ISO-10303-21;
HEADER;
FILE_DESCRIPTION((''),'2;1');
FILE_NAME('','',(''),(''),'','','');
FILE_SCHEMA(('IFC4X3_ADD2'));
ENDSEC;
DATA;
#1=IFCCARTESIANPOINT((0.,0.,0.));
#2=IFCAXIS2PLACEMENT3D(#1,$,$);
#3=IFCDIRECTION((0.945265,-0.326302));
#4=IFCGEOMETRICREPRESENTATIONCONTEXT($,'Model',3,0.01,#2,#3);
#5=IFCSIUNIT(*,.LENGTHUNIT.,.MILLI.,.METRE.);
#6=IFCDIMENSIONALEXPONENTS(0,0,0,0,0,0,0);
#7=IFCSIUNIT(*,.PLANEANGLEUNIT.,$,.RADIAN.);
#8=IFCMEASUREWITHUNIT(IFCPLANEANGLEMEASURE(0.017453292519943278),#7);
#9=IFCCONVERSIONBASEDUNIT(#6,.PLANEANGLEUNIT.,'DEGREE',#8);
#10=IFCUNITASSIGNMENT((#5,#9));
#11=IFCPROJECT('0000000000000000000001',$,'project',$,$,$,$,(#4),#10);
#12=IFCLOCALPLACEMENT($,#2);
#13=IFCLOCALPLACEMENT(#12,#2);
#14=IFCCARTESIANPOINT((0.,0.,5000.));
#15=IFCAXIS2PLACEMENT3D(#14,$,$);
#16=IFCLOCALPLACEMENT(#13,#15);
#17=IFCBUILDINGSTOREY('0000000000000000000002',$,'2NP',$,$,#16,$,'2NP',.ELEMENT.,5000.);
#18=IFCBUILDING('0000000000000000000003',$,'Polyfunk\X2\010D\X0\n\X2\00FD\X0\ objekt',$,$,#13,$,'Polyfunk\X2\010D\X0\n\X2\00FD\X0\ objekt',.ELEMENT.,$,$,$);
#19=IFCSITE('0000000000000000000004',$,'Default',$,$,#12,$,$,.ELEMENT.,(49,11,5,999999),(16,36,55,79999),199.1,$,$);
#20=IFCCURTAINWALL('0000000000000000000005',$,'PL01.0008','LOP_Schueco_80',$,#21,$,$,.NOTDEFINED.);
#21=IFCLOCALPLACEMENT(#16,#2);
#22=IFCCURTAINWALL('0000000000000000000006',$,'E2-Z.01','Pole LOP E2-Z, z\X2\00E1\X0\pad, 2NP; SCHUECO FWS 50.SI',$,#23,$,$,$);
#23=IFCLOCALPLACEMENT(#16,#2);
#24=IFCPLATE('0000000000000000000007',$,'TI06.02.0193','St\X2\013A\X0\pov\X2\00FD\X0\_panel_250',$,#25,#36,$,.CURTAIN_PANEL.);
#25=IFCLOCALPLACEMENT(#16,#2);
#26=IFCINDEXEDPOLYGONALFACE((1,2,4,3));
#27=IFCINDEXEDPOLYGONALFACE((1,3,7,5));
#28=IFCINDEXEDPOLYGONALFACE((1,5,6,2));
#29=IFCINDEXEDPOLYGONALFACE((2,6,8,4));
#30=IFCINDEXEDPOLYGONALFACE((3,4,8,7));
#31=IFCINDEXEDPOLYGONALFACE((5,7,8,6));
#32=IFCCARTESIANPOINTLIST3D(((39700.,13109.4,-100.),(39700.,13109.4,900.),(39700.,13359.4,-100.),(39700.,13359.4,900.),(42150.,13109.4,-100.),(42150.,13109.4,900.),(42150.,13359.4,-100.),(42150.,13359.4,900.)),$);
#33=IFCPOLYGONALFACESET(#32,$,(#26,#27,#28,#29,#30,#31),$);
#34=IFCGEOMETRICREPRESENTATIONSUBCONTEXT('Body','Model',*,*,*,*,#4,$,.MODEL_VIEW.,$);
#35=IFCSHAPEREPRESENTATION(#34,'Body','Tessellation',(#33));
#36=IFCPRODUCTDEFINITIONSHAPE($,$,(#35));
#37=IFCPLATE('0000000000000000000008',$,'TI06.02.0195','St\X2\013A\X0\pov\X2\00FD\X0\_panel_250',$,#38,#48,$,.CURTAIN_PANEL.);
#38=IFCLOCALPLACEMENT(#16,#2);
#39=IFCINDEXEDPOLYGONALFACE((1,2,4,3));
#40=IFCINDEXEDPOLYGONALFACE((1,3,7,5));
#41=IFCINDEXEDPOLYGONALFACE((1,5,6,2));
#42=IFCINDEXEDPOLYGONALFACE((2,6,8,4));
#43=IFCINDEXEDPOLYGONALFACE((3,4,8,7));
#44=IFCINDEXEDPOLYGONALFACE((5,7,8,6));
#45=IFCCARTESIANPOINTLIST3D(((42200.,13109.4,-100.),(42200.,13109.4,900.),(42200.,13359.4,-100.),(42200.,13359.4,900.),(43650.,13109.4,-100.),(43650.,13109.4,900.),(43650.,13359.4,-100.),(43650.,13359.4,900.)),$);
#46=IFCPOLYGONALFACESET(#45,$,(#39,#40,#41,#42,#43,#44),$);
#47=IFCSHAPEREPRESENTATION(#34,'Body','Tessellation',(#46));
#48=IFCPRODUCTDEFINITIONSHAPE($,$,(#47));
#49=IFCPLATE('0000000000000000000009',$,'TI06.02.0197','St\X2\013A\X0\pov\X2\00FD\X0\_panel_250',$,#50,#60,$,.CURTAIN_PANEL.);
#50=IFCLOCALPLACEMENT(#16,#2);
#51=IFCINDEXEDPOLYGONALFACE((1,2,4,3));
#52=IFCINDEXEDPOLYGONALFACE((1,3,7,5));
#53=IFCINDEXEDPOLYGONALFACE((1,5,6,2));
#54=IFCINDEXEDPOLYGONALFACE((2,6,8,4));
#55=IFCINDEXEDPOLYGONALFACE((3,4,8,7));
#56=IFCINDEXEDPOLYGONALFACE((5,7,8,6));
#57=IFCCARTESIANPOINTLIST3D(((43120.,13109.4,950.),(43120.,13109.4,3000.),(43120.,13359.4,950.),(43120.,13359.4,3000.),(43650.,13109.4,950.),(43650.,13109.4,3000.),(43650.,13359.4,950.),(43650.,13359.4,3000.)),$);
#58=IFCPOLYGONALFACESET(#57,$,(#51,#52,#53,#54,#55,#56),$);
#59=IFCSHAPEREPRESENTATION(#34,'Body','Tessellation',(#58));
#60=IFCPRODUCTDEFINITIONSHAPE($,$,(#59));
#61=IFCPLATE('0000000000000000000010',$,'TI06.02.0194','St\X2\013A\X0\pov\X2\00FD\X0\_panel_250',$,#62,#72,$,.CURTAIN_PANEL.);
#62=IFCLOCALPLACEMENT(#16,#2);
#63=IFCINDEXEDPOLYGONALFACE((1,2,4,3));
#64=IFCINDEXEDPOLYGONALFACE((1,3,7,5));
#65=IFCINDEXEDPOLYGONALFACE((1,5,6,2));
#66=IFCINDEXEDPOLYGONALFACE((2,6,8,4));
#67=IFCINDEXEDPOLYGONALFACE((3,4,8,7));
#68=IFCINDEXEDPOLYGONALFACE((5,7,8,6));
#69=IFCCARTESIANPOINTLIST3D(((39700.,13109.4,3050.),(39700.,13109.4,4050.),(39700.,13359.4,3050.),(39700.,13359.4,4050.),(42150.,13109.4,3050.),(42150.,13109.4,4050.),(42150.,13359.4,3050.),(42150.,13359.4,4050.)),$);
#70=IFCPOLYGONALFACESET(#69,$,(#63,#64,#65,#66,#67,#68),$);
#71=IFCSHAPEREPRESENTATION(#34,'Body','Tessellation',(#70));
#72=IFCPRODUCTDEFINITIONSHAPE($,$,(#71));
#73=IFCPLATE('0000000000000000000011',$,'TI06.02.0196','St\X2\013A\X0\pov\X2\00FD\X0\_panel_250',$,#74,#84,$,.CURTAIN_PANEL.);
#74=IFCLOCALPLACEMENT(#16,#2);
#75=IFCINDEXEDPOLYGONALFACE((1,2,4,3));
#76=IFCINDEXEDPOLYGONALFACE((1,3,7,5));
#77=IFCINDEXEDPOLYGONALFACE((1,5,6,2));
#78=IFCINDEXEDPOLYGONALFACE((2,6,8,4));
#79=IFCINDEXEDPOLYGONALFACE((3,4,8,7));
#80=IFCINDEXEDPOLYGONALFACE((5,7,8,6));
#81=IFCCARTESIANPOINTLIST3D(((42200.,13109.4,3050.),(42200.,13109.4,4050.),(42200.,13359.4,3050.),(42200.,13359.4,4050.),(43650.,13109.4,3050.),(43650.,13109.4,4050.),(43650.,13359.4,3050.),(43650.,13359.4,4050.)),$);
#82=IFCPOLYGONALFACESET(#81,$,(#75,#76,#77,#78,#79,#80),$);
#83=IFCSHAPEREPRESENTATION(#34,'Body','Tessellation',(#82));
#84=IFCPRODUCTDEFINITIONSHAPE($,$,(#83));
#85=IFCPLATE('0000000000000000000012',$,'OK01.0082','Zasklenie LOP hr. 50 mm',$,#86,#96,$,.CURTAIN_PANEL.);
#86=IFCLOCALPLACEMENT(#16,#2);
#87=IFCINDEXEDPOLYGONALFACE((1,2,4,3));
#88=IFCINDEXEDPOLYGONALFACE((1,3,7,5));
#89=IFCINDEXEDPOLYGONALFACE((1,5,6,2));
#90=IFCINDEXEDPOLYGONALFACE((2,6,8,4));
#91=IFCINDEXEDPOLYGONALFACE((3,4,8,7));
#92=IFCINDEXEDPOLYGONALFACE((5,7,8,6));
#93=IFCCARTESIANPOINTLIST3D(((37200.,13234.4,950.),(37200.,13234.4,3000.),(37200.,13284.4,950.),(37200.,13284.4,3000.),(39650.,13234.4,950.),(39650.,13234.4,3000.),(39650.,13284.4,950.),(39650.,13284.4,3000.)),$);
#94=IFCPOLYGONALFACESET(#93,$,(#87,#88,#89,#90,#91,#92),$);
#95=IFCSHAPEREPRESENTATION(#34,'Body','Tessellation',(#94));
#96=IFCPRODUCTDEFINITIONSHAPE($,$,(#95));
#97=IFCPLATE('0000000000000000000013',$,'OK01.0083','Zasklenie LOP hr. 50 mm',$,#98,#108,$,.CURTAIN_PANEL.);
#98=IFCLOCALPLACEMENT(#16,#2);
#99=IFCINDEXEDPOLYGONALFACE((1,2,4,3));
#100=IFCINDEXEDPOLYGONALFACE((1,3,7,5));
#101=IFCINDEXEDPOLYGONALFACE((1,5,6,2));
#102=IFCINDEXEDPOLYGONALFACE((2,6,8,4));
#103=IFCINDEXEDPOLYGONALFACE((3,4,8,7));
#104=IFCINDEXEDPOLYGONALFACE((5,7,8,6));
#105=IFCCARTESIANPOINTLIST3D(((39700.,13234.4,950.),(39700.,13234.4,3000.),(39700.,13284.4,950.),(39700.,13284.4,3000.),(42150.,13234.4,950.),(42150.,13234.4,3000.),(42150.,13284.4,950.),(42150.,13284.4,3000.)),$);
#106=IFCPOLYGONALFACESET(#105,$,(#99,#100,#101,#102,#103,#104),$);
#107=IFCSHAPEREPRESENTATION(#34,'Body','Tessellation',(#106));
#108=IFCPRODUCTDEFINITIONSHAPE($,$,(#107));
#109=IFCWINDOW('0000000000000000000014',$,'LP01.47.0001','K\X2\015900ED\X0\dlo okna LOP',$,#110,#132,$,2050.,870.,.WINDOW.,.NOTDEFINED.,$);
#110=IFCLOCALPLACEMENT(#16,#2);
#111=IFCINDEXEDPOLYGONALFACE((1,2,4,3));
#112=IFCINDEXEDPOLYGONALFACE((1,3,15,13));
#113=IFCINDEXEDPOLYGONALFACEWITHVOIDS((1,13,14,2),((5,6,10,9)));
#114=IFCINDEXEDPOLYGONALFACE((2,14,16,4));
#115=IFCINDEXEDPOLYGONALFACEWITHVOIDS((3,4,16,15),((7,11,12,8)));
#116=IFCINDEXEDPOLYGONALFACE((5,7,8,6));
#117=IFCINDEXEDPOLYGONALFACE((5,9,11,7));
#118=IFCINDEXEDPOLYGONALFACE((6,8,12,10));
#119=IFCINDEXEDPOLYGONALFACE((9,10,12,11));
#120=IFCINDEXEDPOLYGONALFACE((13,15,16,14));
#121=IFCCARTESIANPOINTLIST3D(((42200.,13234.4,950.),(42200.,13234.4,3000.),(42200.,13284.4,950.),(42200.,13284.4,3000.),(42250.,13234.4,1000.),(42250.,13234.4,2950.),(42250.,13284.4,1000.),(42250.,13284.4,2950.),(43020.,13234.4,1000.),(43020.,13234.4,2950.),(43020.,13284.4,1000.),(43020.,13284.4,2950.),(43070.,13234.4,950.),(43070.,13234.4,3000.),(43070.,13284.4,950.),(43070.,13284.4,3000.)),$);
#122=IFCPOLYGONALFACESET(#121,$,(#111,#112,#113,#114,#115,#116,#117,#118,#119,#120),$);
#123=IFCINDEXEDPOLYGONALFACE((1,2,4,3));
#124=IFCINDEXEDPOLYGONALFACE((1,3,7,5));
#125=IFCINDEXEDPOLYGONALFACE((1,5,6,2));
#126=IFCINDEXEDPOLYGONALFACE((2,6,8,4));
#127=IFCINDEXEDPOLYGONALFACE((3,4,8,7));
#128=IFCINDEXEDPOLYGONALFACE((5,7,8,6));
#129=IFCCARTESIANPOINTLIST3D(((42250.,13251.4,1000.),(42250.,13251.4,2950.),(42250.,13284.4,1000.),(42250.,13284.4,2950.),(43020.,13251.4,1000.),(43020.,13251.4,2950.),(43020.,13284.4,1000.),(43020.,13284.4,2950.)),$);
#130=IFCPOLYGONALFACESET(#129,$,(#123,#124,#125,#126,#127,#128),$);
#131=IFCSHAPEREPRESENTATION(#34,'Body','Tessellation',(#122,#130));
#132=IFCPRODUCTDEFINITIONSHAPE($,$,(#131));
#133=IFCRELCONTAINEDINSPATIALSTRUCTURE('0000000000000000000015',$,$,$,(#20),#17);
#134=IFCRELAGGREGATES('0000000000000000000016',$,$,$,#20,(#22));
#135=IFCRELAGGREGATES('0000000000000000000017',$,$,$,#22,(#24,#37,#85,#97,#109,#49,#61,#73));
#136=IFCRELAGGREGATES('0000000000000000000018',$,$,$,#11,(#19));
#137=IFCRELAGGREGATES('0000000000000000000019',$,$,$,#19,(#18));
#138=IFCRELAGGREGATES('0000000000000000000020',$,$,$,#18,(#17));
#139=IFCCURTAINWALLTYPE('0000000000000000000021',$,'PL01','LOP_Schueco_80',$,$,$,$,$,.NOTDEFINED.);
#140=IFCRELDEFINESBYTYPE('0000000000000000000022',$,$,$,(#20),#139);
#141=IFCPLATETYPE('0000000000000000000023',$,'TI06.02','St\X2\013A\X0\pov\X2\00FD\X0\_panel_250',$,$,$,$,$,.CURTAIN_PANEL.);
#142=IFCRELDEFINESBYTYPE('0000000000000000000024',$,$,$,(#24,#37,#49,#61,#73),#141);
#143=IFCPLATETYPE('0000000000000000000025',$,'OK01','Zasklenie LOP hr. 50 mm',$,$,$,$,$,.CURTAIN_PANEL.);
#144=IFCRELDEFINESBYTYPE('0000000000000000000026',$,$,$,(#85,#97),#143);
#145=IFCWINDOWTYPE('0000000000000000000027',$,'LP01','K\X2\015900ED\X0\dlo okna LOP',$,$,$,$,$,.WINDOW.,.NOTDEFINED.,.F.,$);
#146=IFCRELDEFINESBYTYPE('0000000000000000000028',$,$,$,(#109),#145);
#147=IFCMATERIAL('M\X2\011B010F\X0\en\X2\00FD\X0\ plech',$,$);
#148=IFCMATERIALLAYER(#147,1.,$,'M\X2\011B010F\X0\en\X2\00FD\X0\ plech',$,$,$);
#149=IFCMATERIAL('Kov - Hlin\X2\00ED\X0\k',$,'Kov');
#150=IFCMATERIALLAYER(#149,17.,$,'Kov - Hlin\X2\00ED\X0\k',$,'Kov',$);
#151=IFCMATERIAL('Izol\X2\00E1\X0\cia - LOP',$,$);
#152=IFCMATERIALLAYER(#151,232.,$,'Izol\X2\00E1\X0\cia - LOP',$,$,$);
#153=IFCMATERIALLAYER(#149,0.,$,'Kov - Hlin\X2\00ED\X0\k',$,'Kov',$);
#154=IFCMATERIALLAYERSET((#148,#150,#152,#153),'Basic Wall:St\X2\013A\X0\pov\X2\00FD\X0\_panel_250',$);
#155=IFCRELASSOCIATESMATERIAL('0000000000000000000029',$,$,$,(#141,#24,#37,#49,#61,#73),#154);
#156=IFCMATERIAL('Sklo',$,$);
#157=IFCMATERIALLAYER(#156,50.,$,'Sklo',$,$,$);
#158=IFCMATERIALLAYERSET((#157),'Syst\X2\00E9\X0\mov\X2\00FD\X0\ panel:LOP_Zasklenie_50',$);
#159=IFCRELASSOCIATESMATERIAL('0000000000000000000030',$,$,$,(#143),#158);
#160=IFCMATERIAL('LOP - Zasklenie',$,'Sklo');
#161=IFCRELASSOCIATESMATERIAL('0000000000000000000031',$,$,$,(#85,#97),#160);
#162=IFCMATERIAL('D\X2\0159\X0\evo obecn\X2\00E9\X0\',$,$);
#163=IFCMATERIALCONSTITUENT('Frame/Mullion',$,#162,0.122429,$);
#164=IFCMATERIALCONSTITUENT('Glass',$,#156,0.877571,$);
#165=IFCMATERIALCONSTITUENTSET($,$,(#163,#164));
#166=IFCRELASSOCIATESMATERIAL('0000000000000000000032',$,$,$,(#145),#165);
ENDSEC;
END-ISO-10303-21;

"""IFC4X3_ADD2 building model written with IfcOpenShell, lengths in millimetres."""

from ifc_helpers import new_model, entity, si_unit, converted_unit, direction, frame, frame_2d, origin, origin_2d_with_axis, place, context, subcontext, project, spatial, polyline, rectangle, outline, extrude, source, transform, mapped, material, layer, layer_set, layer_usage, constituent, constituent_set, type_object, type_shapes, element, aggregate, save


model = new_model("IFC4X3_ADD2")

# Units and contexts
model_context = context("Model", 3, precision=0.01, world=origin(), true_north=direction((0.945265, -0.326302)))
body_context = subcontext(model_context, "Body", "Model", "MODEL_VIEW")
ifc_project = project(units=[si_unit("LENGTHUNIT", "METRE", prefix="MILLI"), converted_unit("PLANEANGLEUNIT", "DEGREE", entity("IfcPlaneAngleMeasure", 0.017453292519943278), si_unit("PLANEANGLEUNIT", "RADIAN"), dimensions=[0, 0, 0, 0, 0, 0, 0])], contexts=[model_context])

# Site, building, storey
site_placement = place(None, origin())
site = spatial("IfcSite", under=ifc_project, at=site_placement, Name="Default", CompositionType="ELEMENT", RefLatitude=(49, 11, 5, 999999), RefLongitude=(16, 36, 55, 79999), RefElevation=199.1)
building_placement = place(site_placement, origin())
building = spatial("IfcBuilding", under=site, at=building_placement, Name="Polyfunkčný objekt", LongName="Polyfunkčný objekt", CompositionType="ELEMENT")
storey_placement = place(building_placement, frame((0.0, 0.0, 5000.0)))
storey = spatial("IfcBuildingStorey", under=building, at=storey_placement, Name="2NP", LongName="2NP", CompositionType="ELEMENT", Elevation=5000.0)

# Curtain walls, plates, window
curtain_wall_type = type_object("IfcCurtainWallType", Name="PL01", Description="LOP_Schueco_80", PredefinedType="NOTDEFINED")
curtain_wall_1_placement = place(storey_placement, frame((0.0, 0.0, -5000.0)))
curtain_wall_1 = element("IfcCurtainWall", 1, at=curtain_wall_1_placement, inside=storey, type_object=curtain_wall_type, Name="PL01.0008", Description="LOP_Schueco_80", PredefinedType="NOTDEFINED")
curtain_wall_2 = element("IfcCurtainWall", 2, Name="E2-Z.01", Description="Pole LOP E2-Z, západ, 2NP; SCHUECO FWS 50.SI")
aggregate(curtain_wall_1, [curtain_wall_2])
ifc_material_1 = material(Name="Měďený plech")
ifc_layer_1 = layer(ifc_material_1, 1.0, Name="Měďený plech")
ifc_material_2 = material(Name="Kov - Hliník", Category="Kov")
ifc_layer_2 = layer(ifc_material_2, 17.0, Name="Kov - Hliník", Category="Kov")
ifc_material_3 = material(Name="Izolácia - LOP")
ifc_layer_3 = layer(ifc_material_3, 232.0, Name="Izolácia - LOP")
ifc_layer_4 = layer(ifc_material_2, 0.0, Name="Kov - Hliník", Category="Kov")
ifc_layer_set_1 = layer_set([ifc_layer_1, ifc_layer_2, ifc_layer_3, ifc_layer_4], Name="Basic Wall:Stĺpový_panel_250")
ifc_layer_usage_1 = layer_usage(ifc_layer_set_1, "AXIS2", "NEGATIVE", 125.0)
plate_type_1 = type_object("IfcPlateType", Name="TI06.02", Description="Stĺpový_panel_250", PredefinedType="CURTAIN_PANEL", material=ifc_layer_set_1)
plate_1_placement = place(storey_placement, frame((39700.0, 13234.4, -100.0)))
plate_1 = element("IfcPlate", 3, at=plate_1_placement, type_object=plate_type_1, material=ifc_layer_usage_1, Name="TI06.02.0193", Description="Stĺpový_panel_250", PredefinedType="CURTAIN_PANEL", context=body_context, shape_type="SweptSolid", body=[
    extrude(rectangle(XDim=250.0, YDim=2450.0, at=frame_2d((0.0, 0.0), x_axis=(1.0, 0.0))), frame((1225.0, 0.0, 0.0), z_axis=(0.0, 0.0, 1.0), x_axis=(0.0, 1.0, 0.0)), (0.0, 0.0, 1.0), 1000.0),
])
ifc_layer_usage_2 = layer_usage(ifc_layer_set_1, "AXIS2", "NEGATIVE", 125.0)
plate_2_placement = place(storey_placement, frame((42200.0, 13234.4, -100.0)))
plate_2 = element("IfcPlate", 4, at=plate_2_placement, type_object=plate_type_1, material=ifc_layer_usage_2, Name="TI06.02.0195", Description="Stĺpový_panel_250", PredefinedType="CURTAIN_PANEL", context=body_context, shape_type="SweptSolid", body=[
    extrude(rectangle(XDim=250.0, YDim=1450.0, at=frame_2d((0.0, 0.0), x_axis=(1.0, 0.0))), frame((725.0, 0.0, 0.0), z_axis=(0.0, 0.0, 1.0), x_axis=(0.0, 1.0, 0.0)), (0.0, 0.0, 1.0), 1000.0),
])
ifc_layer_usage_3 = layer_usage(ifc_layer_set_1, "AXIS2", "NEGATIVE", 125.0)
plate_3_placement = place(storey_placement, frame((43120.0, 13234.4, 950.0)))
plate_3 = element("IfcPlate", 5, at=plate_3_placement, type_object=plate_type_1, material=ifc_layer_usage_3, Name="TI06.02.0197", Description="Stĺpový_panel_250", PredefinedType="CURTAIN_PANEL", context=body_context, shape_type="SweptSolid", body=[
    extrude(rectangle(XDim=250.0, YDim=530.0, at=frame_2d((0.0, 0.0), x_axis=(1.0, 0.0))), frame((265.0, 0.0, 0.0), z_axis=(0.0, 0.0, 1.0), x_axis=(0.0, 1.0, 0.0)), (0.0, 0.0, 1.0), 2050.0),
])
ifc_layer_usage_4 = layer_usage(ifc_layer_set_1, "AXIS2", "NEGATIVE", 125.0)
plate_4_placement = place(storey_placement, frame((39700.0, 13234.4, 3050.0)))
plate_4 = element("IfcPlate", 6, at=plate_4_placement, type_object=plate_type_1, material=ifc_layer_usage_4, Name="TI06.02.0194", Description="Stĺpový_panel_250", PredefinedType="CURTAIN_PANEL", context=body_context, shape_type="SweptSolid", body=[
    extrude(rectangle(XDim=250.0, YDim=2450.0, at=frame_2d((0.0, 0.0), x_axis=(1.0, 0.0))), frame((1225.0, 0.0, 0.0), z_axis=(0.0, 0.0, 1.0), x_axis=(0.0, 1.0, 0.0)), (0.0, 0.0, 1.0), 1000.0),
])
ifc_layer_usage_5 = layer_usage(ifc_layer_set_1, "AXIS2", "NEGATIVE", 125.0)
plate_5_placement = place(storey_placement, frame((42200.0, 13234.4, 3050.0)))
plate_5 = element("IfcPlate", 7, at=plate_5_placement, type_object=plate_type_1, material=ifc_layer_usage_5, Name="TI06.02.0196", Description="Stĺpový_panel_250", PredefinedType="CURTAIN_PANEL", context=body_context, shape_type="SweptSolid", body=[
    extrude(rectangle(XDim=250.0, YDim=1450.0, at=frame_2d((0.0, 0.0), x_axis=(1.0, 0.0))), frame((725.0, 0.0, 0.0), z_axis=(0.0, 0.0, 1.0), x_axis=(0.0, 1.0, 0.0)), (0.0, 0.0, 1.0), 1000.0),
])
ifc_material_4 = material(Name="LOP - Zasklenie", Category="Sklo")
ifc_material_5 = material(Name="Sklo")
ifc_layer_5 = layer(ifc_material_5, 50.0, Name="Sklo")
ifc_layer_set_2 = layer_set([ifc_layer_5], Name="Systémový panel:LOP_Zasklenie_50")
plate_type_2 = type_object("IfcPlateType", Name="OK01", Description="Zasklenie LOP hr. 50 mm", PredefinedType="CURTAIN_PANEL", material=ifc_layer_set_2)
shared_shape_1 = source(origin(), body_context, "Body", "SweptSolid", [
    extrude(rectangle(XDim=50.0, YDim=2450.0, at=origin_2d_with_axis()), frame((0.0, 25.0, 0.0), z_axis=(0.0, 0.0, 1.0), x_axis=(0.0, 1.0, 0.0)), (0.0, 0.0, 1.0), 2050.0),
])
type_shapes(plate_type_2, [shared_shape_1])
plate_6_placement = place(curtain_wall_1_placement, frame((38425.0, 13234.4, 5950.0)))
plate_6 = element("IfcPlate", 8, at=plate_6_placement, type_object=plate_type_2, material=ifc_material_4, Name="OK01.0082", Description="Zasklenie LOP hr. 50 mm", PredefinedType="CURTAIN_PANEL", context=body_context, shape_type="MappedRepresentation", body=[
    mapped(shared_shape_1, transform((0.0, 0.0, 0.0), scale=1.0)),
])
plate_7_placement = place(curtain_wall_1_placement, frame((40925.0, 13234.4, 5950.0)))
plate_7 = element("IfcPlate", 9, at=plate_7_placement, type_object=plate_type_2, material=ifc_material_4, Name="OK01.0083", Description="Zasklenie LOP hr. 50 mm", PredefinedType="CURTAIN_PANEL", context=body_context, shape_type="MappedRepresentation", body=[
    mapped(shared_shape_1, transform((0.0, 0.0, 0.0), scale=1.0)),
])
ifc_material_6 = material(Name="Dřevo obecné")
ifc_constituent_1 = constituent(ifc_material_6, Name="Frame/Mullion", fraction=0.122429)
ifc_constituent_2 = constituent(ifc_material_5, Name="Glass", fraction=0.877571)
ifc_constituent_set = constituent_set(constituents=[ifc_constituent_1, ifc_constituent_2])
window_type = type_object("IfcWindowType", Name="LP01", Description="Křídlo okna LOP", ParameterTakesPrecedence=False, PartitioningType="NOTDEFINED", PredefinedType="WINDOW", material=ifc_constituent_set)
shared_shape_2 = source(origin(), body_context, "Body", "SweptSolid", [
    extrude(outline(polyline([(-1025.0, -435.0), (1025.0, -435.0), (1025.0, 435.0), (-1025.0, 435.0), (-1025.0, -435.0)]), holes=[polyline([(-975.0, -385.0), (-975.0, 385.0), (975.0, 385.0), (975.0, -385.0), (-975.0, -385.0)])]), frame((0.0, 0.0, 1025.0), z_axis=(0.0, 1.0, 0.0), x_axis=(0.0, 0.0, -1.0)), (0.0, 0.0, 1.0), 50.0),
    extrude(rectangle(XDim=33.0, YDim=770.0, at=origin_2d_with_axis()), frame((0.0, 33.5, 50.0), z_axis=(0.0, 0.0, 1.0), x_axis=(0.0, -1.0, 0.0)), (0.0, 0.0, 1.0), 1950.0),
])
type_shapes(window_type, [shared_shape_2])
window_placement = place(curtain_wall_1_placement, frame((42635.0, 13234.4, 5950.0)))
window = element("IfcWindow", 10, at=window_placement, type_object=window_type, Name="LP01.47.0001", Description="Křídlo okna LOP", OverallHeight=2050.0, OverallWidth=870.0, PartitioningType="NOTDEFINED", PredefinedType="WINDOW", context=body_context, shape_type="MappedRepresentation", body=[
    mapped(shared_shape_2, transform((0.0, 0.0, 0.0), scale=1.0)),
])
aggregate(curtain_wall_2, [plate_1, plate_2, plate_6, plate_7, window, plate_3, plate_4, plate_5])

save(model, "model.ifc")
